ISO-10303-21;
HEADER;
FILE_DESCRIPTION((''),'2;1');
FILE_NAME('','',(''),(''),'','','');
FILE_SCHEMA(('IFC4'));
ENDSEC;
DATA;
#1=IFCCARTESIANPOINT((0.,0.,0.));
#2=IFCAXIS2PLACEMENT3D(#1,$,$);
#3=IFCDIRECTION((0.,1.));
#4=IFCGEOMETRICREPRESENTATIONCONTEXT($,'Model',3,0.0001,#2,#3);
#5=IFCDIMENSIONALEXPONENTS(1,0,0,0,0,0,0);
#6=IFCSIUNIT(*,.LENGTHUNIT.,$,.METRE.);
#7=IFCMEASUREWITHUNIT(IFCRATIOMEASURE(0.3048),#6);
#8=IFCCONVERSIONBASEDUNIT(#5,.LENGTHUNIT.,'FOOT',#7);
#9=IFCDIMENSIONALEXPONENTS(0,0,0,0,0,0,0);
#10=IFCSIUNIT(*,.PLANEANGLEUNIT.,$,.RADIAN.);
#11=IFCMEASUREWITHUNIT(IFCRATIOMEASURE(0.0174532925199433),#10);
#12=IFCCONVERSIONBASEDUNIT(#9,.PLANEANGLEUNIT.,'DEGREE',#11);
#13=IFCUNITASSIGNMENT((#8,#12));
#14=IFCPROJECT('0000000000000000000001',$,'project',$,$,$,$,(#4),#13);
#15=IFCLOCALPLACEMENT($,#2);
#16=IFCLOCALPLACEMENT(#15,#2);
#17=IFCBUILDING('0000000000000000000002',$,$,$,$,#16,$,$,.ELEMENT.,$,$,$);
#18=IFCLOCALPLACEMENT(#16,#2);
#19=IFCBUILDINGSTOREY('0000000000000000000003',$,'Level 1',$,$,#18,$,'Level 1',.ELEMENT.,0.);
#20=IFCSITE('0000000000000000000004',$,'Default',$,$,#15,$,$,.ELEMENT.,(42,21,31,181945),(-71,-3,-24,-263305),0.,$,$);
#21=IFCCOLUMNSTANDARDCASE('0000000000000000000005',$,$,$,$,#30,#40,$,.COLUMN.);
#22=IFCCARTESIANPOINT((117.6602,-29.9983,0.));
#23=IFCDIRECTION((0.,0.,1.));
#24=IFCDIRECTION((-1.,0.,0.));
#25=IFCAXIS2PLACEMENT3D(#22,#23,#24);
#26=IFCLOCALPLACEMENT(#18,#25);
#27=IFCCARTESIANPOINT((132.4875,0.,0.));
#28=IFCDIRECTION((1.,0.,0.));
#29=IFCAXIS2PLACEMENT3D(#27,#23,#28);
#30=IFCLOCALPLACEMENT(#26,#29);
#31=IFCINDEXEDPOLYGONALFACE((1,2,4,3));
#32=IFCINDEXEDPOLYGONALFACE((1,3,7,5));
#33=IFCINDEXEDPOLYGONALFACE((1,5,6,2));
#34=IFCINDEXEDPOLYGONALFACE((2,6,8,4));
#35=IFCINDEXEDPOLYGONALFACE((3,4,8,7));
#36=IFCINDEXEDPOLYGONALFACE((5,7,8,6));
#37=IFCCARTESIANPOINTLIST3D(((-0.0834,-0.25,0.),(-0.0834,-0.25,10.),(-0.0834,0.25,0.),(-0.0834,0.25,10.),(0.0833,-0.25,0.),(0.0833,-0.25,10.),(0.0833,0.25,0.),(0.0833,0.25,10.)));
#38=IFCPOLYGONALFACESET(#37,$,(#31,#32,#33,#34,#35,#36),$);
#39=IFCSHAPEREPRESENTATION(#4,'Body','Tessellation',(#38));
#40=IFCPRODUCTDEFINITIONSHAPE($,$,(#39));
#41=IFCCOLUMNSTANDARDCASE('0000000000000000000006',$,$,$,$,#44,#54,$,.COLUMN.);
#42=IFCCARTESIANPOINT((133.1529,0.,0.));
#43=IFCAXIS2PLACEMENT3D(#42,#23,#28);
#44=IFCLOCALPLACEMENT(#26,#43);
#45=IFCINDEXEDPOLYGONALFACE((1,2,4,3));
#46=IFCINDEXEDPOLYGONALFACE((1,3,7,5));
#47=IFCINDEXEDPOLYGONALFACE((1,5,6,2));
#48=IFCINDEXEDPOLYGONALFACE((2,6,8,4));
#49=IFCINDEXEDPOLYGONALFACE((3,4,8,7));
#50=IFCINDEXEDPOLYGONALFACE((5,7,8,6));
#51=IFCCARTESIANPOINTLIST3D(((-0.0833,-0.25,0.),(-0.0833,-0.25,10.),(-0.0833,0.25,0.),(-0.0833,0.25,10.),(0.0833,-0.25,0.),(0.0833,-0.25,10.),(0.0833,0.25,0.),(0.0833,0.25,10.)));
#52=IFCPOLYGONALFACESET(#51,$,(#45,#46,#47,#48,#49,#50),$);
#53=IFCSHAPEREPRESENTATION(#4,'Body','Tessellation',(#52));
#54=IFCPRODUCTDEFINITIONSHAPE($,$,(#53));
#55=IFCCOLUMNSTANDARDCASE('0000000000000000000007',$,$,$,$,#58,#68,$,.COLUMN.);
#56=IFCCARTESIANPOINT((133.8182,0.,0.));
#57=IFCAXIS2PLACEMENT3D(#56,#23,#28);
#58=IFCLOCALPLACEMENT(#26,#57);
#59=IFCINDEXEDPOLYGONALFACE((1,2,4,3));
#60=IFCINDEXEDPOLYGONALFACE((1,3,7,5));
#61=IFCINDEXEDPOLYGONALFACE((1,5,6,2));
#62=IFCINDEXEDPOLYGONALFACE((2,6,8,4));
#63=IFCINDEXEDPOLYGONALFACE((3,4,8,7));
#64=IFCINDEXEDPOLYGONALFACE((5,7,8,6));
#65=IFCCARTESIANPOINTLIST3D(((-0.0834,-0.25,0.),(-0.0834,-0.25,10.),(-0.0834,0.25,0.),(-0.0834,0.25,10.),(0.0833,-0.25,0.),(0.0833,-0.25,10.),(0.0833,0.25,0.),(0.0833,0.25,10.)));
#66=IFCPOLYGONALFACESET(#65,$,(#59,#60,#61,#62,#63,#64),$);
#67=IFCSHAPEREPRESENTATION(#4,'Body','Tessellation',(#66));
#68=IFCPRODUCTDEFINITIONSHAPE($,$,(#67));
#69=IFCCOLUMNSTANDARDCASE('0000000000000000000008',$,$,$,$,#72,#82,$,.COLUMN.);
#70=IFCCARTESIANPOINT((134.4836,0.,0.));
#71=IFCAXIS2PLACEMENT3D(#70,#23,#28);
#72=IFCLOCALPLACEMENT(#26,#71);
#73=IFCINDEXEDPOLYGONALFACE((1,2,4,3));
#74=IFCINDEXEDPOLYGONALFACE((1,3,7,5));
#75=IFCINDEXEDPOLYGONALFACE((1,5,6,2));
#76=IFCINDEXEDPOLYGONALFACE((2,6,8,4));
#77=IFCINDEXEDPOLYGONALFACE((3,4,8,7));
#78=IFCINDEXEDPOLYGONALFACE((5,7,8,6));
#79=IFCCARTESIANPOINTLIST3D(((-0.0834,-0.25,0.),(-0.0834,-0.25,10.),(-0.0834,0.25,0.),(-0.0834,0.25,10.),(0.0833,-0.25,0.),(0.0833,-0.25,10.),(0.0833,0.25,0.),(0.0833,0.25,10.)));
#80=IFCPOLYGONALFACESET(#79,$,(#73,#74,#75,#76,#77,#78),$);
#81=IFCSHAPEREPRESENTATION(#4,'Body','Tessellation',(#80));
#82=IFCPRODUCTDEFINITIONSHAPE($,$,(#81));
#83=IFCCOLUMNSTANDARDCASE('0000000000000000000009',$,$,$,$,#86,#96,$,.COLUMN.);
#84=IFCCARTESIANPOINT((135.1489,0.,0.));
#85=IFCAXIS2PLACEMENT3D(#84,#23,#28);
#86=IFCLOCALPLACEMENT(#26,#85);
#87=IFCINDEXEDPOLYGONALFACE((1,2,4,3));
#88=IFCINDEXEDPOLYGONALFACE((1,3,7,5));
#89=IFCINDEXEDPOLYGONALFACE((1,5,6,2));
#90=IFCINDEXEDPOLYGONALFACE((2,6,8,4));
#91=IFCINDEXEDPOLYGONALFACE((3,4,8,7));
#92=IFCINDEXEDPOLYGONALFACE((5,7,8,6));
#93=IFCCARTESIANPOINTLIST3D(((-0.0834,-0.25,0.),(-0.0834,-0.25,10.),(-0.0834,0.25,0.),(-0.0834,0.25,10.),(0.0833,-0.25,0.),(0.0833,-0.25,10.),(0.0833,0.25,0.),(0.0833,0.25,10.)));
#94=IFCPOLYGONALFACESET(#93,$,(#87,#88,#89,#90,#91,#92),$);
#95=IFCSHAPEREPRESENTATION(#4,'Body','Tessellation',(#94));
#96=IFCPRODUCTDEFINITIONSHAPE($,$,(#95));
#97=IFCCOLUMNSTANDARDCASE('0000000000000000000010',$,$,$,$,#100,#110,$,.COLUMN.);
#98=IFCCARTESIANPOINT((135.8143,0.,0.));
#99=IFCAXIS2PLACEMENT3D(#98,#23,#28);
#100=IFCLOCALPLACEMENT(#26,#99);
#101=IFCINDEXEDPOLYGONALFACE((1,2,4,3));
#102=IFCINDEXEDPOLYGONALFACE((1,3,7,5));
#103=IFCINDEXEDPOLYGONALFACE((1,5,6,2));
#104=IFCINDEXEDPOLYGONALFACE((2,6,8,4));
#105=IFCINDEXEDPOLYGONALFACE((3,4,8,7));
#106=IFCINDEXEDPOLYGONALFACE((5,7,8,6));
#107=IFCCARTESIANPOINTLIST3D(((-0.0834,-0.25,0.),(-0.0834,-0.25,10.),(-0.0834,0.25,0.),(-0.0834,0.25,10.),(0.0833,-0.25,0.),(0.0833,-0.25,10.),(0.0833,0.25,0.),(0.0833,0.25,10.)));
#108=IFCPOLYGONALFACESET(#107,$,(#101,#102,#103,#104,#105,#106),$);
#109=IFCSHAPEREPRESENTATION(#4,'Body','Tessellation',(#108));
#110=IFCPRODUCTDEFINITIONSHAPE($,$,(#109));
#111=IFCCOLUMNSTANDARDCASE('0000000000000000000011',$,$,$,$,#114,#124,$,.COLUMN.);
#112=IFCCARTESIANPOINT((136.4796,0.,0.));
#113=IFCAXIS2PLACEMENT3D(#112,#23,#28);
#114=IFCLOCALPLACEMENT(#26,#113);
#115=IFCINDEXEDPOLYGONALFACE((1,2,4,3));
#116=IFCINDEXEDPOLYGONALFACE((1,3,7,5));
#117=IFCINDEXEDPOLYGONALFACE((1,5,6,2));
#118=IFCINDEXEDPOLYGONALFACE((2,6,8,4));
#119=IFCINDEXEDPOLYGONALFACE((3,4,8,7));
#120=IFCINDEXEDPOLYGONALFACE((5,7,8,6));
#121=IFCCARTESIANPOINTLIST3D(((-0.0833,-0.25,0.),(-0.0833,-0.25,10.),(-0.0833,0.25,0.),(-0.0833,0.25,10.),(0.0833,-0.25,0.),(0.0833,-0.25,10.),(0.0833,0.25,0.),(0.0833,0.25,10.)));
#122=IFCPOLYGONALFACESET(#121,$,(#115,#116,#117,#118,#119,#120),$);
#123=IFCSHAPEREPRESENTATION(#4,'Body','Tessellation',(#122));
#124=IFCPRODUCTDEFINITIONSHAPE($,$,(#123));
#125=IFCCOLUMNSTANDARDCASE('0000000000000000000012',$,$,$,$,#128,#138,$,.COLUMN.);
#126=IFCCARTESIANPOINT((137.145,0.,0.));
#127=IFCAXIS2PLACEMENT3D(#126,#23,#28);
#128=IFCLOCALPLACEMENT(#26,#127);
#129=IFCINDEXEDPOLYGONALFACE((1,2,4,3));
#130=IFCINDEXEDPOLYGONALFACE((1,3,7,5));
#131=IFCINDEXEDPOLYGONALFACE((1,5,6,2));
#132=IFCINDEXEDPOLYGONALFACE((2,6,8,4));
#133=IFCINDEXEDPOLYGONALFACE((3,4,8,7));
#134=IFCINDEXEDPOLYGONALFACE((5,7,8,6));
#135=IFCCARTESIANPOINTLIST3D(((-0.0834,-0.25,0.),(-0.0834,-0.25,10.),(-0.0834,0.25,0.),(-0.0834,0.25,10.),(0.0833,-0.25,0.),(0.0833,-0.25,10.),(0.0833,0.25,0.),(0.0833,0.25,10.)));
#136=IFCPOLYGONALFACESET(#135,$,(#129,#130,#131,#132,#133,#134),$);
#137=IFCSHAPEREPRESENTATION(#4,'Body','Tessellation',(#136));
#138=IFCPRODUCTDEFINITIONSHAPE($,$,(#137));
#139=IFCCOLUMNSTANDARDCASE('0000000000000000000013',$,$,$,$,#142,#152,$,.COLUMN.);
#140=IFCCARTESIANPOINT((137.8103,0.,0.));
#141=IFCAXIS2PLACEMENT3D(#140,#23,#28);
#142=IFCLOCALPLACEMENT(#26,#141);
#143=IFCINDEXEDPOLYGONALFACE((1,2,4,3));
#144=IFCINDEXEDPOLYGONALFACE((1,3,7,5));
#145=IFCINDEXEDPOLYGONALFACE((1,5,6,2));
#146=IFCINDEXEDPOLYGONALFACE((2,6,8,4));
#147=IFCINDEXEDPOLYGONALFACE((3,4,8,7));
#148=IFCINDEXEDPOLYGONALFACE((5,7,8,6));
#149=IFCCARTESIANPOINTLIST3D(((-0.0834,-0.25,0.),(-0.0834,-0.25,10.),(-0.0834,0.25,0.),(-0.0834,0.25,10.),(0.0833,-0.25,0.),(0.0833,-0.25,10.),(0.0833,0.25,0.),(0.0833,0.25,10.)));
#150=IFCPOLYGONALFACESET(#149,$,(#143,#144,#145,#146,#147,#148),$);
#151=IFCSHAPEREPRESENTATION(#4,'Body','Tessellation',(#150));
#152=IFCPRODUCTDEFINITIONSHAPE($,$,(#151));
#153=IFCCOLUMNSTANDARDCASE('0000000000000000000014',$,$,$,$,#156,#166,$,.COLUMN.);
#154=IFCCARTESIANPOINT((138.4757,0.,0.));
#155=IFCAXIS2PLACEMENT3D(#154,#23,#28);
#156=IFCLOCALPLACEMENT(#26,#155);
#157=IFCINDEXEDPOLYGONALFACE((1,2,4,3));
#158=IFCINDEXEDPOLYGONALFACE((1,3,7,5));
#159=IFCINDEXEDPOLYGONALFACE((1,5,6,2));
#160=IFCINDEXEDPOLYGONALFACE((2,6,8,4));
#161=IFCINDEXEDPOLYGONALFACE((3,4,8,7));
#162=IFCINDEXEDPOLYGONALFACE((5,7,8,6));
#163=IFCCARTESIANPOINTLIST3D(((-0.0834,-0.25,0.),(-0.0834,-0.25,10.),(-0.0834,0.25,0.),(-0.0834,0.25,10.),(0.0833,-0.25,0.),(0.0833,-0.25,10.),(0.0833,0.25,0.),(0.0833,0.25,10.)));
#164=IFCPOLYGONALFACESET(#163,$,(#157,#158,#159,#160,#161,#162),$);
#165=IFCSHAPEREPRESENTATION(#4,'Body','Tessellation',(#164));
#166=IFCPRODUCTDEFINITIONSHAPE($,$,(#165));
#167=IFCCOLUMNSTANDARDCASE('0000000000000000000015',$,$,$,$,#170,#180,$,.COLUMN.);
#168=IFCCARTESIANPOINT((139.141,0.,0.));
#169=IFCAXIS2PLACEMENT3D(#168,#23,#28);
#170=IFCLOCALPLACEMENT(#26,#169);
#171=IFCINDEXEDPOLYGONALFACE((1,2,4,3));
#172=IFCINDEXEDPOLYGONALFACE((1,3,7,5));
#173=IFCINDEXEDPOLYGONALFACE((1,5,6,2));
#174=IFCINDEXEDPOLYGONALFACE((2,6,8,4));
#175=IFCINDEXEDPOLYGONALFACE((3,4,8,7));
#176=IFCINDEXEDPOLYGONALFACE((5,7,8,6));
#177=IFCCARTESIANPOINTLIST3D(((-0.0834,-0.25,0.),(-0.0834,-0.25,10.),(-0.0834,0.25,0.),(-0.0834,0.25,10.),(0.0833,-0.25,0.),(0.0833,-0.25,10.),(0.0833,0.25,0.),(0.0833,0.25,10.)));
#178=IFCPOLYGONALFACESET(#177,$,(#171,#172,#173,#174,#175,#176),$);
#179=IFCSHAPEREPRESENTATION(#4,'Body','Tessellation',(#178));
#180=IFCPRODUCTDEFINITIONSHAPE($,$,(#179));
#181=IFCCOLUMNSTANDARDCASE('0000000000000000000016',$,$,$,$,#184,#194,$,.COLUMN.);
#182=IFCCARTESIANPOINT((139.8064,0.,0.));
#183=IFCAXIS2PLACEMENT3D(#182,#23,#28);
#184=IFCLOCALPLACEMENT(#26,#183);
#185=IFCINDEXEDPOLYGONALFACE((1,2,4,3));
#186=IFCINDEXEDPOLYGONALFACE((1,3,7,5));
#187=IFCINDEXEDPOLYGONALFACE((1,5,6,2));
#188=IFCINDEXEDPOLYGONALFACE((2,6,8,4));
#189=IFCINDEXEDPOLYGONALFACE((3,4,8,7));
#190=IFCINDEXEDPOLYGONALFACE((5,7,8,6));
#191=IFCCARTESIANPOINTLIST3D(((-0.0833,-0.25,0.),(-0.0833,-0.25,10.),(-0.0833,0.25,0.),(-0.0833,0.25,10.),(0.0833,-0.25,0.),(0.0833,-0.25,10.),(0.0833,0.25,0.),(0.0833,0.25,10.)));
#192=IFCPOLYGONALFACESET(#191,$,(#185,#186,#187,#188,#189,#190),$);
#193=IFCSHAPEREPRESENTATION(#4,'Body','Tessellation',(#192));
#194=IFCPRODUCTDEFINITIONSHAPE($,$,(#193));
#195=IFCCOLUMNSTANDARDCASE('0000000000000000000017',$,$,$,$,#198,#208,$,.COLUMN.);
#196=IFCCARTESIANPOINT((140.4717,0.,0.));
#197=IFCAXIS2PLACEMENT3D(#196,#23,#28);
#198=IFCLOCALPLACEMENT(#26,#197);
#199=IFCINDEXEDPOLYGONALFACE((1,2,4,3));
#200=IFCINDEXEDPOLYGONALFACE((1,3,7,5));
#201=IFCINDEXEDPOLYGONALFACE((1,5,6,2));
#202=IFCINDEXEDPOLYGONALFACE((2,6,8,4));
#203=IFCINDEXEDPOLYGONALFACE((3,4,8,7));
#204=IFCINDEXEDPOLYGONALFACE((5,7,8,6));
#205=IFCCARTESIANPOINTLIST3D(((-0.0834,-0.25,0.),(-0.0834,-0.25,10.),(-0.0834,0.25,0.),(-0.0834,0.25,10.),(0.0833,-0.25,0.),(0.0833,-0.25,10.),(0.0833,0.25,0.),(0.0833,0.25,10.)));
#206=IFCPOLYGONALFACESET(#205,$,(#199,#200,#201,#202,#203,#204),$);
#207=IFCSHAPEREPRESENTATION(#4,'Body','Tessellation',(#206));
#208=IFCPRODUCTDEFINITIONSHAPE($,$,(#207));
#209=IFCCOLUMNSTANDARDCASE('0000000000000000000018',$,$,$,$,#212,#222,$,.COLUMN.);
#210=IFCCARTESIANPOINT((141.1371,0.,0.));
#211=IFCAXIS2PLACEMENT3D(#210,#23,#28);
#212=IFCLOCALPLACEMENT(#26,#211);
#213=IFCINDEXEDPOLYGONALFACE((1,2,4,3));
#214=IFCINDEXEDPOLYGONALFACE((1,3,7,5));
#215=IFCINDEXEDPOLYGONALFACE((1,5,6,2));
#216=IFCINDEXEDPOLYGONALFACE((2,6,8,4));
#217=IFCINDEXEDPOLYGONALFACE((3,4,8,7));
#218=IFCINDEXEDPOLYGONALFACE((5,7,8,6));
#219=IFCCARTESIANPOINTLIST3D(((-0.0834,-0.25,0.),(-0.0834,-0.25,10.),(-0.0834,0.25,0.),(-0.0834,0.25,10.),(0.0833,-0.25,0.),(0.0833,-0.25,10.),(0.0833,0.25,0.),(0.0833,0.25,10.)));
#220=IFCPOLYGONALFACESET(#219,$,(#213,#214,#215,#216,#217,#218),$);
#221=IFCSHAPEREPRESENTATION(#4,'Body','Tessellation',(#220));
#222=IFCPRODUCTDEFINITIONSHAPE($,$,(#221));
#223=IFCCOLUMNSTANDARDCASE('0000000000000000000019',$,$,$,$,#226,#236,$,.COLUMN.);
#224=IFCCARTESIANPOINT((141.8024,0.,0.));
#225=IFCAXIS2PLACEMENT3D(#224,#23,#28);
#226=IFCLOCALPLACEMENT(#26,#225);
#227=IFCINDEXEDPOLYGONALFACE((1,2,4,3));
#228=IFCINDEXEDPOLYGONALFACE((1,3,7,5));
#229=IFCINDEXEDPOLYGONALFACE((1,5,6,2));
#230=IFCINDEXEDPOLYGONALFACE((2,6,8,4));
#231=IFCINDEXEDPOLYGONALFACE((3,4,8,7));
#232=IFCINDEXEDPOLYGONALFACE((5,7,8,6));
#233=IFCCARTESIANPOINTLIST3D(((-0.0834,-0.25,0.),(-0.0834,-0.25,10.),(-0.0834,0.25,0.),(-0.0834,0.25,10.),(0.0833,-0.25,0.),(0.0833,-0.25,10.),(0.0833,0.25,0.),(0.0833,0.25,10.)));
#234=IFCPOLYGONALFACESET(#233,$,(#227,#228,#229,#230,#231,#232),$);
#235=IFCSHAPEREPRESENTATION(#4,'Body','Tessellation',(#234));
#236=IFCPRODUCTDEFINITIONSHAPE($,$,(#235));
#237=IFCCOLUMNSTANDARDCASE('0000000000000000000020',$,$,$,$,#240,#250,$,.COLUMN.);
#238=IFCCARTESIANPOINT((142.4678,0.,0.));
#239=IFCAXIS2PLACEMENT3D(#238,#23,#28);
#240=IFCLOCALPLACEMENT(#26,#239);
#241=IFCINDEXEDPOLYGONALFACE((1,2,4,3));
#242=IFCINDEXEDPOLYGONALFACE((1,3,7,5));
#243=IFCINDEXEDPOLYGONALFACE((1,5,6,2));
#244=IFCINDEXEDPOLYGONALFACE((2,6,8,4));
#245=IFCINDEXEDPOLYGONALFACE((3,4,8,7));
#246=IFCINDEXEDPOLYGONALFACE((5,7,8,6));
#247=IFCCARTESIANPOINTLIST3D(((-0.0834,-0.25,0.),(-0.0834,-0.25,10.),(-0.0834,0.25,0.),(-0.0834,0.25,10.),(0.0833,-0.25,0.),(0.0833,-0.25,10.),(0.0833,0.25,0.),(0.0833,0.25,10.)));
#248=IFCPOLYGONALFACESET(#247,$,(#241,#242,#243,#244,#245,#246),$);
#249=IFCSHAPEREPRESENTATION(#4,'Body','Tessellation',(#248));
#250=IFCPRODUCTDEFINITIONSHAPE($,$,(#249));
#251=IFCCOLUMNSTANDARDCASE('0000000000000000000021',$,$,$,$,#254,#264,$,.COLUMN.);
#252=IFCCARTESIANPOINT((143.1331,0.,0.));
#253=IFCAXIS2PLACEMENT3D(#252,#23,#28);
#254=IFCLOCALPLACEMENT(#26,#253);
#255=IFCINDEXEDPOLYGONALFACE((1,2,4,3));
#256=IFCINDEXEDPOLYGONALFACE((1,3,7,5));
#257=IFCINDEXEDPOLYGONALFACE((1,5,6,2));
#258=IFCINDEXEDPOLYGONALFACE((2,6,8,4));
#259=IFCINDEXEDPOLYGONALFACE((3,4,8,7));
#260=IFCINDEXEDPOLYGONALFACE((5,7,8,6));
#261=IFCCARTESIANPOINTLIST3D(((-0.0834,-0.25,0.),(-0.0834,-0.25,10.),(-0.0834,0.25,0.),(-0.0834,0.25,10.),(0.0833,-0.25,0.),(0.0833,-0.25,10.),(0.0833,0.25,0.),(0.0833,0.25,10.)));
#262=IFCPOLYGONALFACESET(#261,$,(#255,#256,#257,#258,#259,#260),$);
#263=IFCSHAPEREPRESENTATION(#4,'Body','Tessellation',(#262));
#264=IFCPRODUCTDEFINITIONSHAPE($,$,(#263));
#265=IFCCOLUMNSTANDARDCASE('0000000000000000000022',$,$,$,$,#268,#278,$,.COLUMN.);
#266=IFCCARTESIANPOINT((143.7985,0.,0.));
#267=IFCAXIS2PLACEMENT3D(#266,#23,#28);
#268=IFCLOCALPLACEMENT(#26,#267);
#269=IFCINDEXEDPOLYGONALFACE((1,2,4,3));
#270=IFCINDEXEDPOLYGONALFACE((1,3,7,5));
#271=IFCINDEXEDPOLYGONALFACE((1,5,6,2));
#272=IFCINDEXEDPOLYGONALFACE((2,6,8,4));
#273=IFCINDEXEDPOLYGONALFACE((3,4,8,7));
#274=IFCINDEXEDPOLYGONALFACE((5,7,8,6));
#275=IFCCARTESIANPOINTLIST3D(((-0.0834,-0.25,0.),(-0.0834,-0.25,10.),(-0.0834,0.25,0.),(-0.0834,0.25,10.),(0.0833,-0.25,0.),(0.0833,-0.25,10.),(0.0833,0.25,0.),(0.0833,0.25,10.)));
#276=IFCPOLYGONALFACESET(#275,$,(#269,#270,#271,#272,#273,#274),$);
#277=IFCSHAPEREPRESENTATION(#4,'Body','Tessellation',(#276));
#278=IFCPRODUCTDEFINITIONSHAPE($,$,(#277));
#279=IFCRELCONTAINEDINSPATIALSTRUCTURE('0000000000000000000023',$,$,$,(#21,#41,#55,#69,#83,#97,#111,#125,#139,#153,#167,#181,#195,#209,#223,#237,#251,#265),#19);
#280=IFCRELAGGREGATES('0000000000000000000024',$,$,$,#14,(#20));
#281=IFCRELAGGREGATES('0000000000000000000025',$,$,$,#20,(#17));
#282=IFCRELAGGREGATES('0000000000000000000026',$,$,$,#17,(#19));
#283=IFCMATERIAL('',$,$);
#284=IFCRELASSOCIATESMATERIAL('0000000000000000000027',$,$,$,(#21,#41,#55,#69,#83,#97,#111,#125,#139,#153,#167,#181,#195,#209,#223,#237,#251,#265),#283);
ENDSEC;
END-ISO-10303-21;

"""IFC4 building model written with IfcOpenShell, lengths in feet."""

from ifc_helpers import new_model, entity, si_unit, converted_unit, direction, frame, origin, place, context, project, spatial, rectangle, extrude, material, element, save


model = new_model("IFC4")

# Units and contexts
model_context = context("Model", 3, precision=0.0001, world=origin(), true_north=direction((0.0, 1.0)))
ifc_project = project(units=[converted_unit("LENGTHUNIT", "FOOT", entity("IfcRatioMeasure", 0.3048), si_unit("LENGTHUNIT", "METRE"), dimensions=[1, 0, 0, 0, 0, 0, 0]), converted_unit("PLANEANGLEUNIT", "DEGREE", entity("IfcRatioMeasure", 0.0174532925199433), si_unit("PLANEANGLEUNIT", "RADIAN"), dimensions=[0, 0, 0, 0, 0, 0, 0])], contexts=[model_context])

# Site, building, storey
site_placement = place(None, origin())
site = spatial("IfcSite", under=ifc_project, at=site_placement, Name="Default", CompositionType="ELEMENT", RefLatitude=(42, 21, 31, 181945), RefLongitude=(-71, -3, -24, -263305), RefElevation=0.0)
building_placement = place(site_placement, origin())
building = spatial("IfcBuilding", under=site, at=building_placement, CompositionType="ELEMENT")
storey_placement = place(building_placement, origin())
storey = spatial("IfcBuildingStorey", under=building, at=storey_placement, Name="Level 1", LongName="Level 1", CompositionType="ELEMENT", Elevation=0.0)

# Columns
ifc_material = material(Name="")
placement = place(storey_placement, frame((117.6602, -29.9983, 0.0), z_axis=(0.0, 0.0, 1.0), x_axis=(-1.0, 0.0, 0.0)))
for number, where, z_axis, x_axis in (
    (1, (132.4875, 0.0, 0.0), (0.0, 0.0, 1.0), (1.0, 0.0, 0.0)),
    (2, (133.1529, 0.0, 0.0), (0.0, 0.0, 1.0), (1.0, 0.0, 0.0)),
    (3, (133.8182, 0.0, 0.0), (0.0, 0.0, 1.0), (1.0, 0.0, 0.0)),
    (4, (134.4836, 0.0, 0.0), (0.0, 0.0, 1.0), (1.0, 0.0, 0.0)),
    (5, (135.1489, 0.0, 0.0), (0.0, 0.0, 1.0), (1.0, 0.0, 0.0)),
    (6, (135.8143, 0.0, 0.0), (0.0, 0.0, 1.0), (1.0, 0.0, 0.0)),
    (7, (136.4796, 0.0, 0.0), (0.0, 0.0, 1.0), (1.0, 0.0, 0.0)),
    (8, (137.145, 0.0, 0.0), (0.0, 0.0, 1.0), (1.0, 0.0, 0.0)),
    (9, (137.8103, 0.0, 0.0), (0.0, 0.0, 1.0), (1.0, 0.0, 0.0)),
    (10, (138.4757, 0.0, 0.0), (0.0, 0.0, 1.0), (1.0, 0.0, 0.0)),
    (11, (139.141, 0.0, 0.0), (0.0, 0.0, 1.0), (1.0, 0.0, 0.0)),
    (12, (139.8064, 0.0, 0.0), (0.0, 0.0, 1.0), (1.0, 0.0, 0.0)),
    (13, (140.4717, 0.0, 0.0), (0.0, 0.0, 1.0), (1.0, 0.0, 0.0)),
    (14, (141.1371, 0.0, 0.0), (0.0, 0.0, 1.0), (1.0, 0.0, 0.0)),
    (15, (141.8024, 0.0, 0.0), (0.0, 0.0, 1.0), (1.0, 0.0, 0.0)),
    (16, (142.4678, 0.0, 0.0), (0.0, 0.0, 1.0), (1.0, 0.0, 0.0)),
    (17, (143.1331, 0.0, 0.0), (0.0, 0.0, 1.0), (1.0, 0.0, 0.0)),
    (18, (143.7985, 0.0, 0.0), (0.0, 0.0, 1.0), (1.0, 0.0, 0.0)),
):
    element("IfcColumnStandardCase", number, at=place(placement, frame(where, z_axis=z_axis, x_axis=x_axis)), inside=storey, material=ifc_material, PredefinedType="COLUMN", context=model_context, shape_type="SweptSolid", body=[
        extrude(rectangle(XDim=0.1667, YDim=0.5), origin(), (0.0, 0.0, 1.0), 10.0),
    ])

save(model, "model.ifc")
